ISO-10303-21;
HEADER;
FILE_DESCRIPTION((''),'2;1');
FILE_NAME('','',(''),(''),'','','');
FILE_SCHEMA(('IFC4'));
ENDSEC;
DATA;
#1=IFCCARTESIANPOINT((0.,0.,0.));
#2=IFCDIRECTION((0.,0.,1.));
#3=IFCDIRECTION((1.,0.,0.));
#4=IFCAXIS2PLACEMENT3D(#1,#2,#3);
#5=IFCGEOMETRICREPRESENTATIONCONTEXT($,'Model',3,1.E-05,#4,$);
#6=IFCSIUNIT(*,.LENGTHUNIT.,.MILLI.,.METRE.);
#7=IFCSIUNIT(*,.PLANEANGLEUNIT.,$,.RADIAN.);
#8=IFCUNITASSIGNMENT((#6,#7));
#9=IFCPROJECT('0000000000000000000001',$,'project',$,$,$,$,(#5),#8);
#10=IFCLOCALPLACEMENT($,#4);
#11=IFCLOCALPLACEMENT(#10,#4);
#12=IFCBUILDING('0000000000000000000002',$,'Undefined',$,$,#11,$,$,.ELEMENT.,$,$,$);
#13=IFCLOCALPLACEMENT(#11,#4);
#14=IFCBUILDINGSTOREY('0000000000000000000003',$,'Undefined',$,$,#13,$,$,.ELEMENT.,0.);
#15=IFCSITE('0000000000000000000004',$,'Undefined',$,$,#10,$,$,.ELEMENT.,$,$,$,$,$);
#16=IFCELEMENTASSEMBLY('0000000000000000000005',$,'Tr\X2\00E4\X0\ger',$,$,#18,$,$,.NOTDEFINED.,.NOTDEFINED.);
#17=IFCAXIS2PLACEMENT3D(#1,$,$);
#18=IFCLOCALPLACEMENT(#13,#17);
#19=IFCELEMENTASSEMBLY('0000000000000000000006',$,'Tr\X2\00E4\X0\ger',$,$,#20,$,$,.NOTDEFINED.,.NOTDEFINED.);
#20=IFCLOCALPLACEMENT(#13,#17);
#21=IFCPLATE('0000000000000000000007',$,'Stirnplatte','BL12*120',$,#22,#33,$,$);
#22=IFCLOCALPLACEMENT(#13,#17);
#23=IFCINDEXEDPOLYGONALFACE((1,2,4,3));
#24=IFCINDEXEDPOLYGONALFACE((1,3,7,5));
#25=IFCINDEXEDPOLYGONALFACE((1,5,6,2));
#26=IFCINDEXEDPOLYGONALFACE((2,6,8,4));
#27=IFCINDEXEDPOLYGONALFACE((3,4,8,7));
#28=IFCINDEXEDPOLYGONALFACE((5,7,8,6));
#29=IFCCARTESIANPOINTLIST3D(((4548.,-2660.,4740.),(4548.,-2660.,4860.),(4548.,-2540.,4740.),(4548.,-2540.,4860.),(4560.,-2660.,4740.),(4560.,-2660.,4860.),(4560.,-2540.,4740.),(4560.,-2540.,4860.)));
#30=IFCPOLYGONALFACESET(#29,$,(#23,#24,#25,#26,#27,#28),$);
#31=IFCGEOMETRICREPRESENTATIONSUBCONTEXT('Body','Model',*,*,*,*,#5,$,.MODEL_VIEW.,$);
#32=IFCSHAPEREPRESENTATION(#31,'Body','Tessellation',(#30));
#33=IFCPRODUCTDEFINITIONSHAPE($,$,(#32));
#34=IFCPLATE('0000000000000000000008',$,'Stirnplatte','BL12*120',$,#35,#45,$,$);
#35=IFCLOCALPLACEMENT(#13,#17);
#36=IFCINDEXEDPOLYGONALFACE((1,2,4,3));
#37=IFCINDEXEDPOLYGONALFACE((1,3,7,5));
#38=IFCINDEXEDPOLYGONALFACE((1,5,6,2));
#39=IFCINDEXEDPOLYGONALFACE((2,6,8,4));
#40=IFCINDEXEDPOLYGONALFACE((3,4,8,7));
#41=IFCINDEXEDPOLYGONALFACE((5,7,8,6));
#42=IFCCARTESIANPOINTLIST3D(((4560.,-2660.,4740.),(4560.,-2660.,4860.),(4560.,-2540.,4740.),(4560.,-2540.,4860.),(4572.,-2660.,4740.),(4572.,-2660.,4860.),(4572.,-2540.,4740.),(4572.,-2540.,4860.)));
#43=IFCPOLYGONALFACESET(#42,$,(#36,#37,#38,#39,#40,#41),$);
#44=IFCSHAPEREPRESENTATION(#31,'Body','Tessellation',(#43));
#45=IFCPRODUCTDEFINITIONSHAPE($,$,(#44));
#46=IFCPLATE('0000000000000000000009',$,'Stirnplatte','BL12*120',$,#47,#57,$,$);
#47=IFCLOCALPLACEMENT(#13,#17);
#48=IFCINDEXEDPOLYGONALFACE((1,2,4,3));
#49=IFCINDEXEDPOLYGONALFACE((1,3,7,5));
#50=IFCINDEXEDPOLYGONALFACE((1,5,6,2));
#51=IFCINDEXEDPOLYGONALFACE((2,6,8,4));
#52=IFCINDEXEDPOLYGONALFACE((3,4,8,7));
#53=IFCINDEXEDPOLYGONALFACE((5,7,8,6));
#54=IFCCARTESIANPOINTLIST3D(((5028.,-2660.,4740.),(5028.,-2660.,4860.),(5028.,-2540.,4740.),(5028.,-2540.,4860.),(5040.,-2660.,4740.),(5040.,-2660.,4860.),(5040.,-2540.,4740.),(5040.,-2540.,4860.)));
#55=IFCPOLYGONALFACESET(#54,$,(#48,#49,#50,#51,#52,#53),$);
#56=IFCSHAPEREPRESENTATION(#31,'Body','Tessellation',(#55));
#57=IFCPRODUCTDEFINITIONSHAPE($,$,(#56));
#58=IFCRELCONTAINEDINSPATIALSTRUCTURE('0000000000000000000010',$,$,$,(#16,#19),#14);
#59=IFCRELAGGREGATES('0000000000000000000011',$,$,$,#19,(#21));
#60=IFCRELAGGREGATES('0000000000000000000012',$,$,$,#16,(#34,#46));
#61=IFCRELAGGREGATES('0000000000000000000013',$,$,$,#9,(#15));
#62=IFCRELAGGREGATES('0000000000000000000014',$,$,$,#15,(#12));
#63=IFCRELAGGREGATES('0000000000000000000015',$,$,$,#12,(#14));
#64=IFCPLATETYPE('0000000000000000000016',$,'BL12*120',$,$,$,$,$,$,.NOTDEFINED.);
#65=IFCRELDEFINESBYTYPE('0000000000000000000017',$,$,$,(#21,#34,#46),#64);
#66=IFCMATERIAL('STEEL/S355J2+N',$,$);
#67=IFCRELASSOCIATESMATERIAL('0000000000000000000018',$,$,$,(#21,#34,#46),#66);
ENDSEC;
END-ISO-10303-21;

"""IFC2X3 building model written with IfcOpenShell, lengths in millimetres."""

from ifc_helpers import new_model, si_unit, frame, origin_with_axes, place, context, subcontext, project, spatial, polyline, outline, extrude, material, type_object, element, aggregate, save


model = new_model("IFC2X3")

# Units and contexts
model_context = context("Model", 3, precision=1e-05, world=origin_with_axes())
body_context = subcontext(model_context, "Body", "Model", "MODEL_VIEW")
ifc_project = project(units=[si_unit("LENGTHUNIT", "METRE", prefix="MILLI"), si_unit("PLANEANGLEUNIT", "RADIAN")], contexts=[model_context])

# Site, building, storey
site_placement = place(None, origin_with_axes())
site = spatial("IfcSite", under=ifc_project, at=site_placement, Name="Undefined", CompositionType="ELEMENT")
building_placement = place(site_placement, origin_with_axes())
building = spatial("IfcBuilding", under=site, at=building_placement, Name="Undefined", CompositionType="ELEMENT")
storey_placement = place(building_placement, origin_with_axes())
storey = spatial("IfcBuildingStorey", under=building, at=storey_placement, Name="Undefined", CompositionType="ELEMENT", Elevation=0.0)

# Element assembly
assembly_1_placement = place(storey_placement, origin_with_axes())
assembly_1 = element("IfcElementAssembly", 1, at=assembly_1_placement, inside=storey, Name="Träger", AssemblyPlace="NOTDEFINED", PredefinedType="NOTDEFINED")

# Shared definitions
ifc_material_1 = material(Name="STEEL/S355J2+N")
plate_type_1 = type_object("IfcPlateType", Name="BL12*120", PredefinedType="NOTDEFINED")

# Element assembly, plate
assembly_2_placement = place(storey_placement, origin_with_axes())
assembly_2 = element("IfcElementAssembly", 2, at=assembly_2_placement, inside=storey, Name="Träger", AssemblyPlace="NOTDEFINED", PredefinedType="NOTDEFINED")
plate_1_placement = place(assembly_2_placement, frame((4554.0, -2600.0, 4740.0), z_axis=(-1.0, 0.0, 0.0), x_axis=(0.0, 0.0, 1.0)))
plate_1 = element("IfcPlate", 3, at=plate_1_placement, type_object=plate_type_1, material=ifc_material_1, Name="Stirnplatte", Description="BL12*120", context=body_context, shape_type="SweptSolid", body=[
    extrude(outline(polyline([(0.0, -60.0), (0.0, 60.0), (120.0, 60.0), (120.0, -60.0), (0.0, -60.0)])), frame((0.0, 0.0, -6.0), z_axis=(0.0, 0.0, 1.0), x_axis=(1.0, 0.0, 0.0)), (0.0, 0.0, 1.0), 12.0),
])
aggregate(assembly_2, [plate_1])

# Plates
plate_2_placement = place(assembly_1_placement, frame((4566.0, -2600.0, 4740.0), z_axis=(-1.0, 0.0, 0.0), x_axis=(0.0, 0.0, 1.0)))
plate_2 = element("IfcPlate", 4, at=plate_2_placement, type_object=plate_type_1, material=ifc_material_1, Name="Stirnplatte", Description="BL12*120", context=body_context, shape_type="SweptSolid", body=[
    extrude(outline(polyline([(0.0, -60.0), (0.0, 60.0), (120.0, 60.0), (120.0, -60.0), (0.0, -60.0)])), frame((0.0, 0.0, -6.0), z_axis=(0.0, 0.0, 1.0), x_axis=(1.0, 0.0, 0.0)), (0.0, 0.0, 1.0), 12.0),
])
plate_3_placement = place(assembly_1_placement, frame((5034.0, -2600.0, 4740.0), z_axis=(1.0, 0.0, 0.0), x_axis=(0.0, 0.0, 1.0)))
plate_3 = element("IfcPlate", 5, at=plate_3_placement, type_object=plate_type_1, material=ifc_material_1, Name="Stirnplatte", Description="BL12*120", context=body_context, shape_type="SweptSolid", body=[
    extrude(outline(polyline([(0.0, -60.0), (0.0, 60.0), (120.0, 60.0), (120.0, -60.0), (0.0, -60.0)])), frame((0.0, 0.0, -6.0), z_axis=(0.0, 0.0, 1.0), x_axis=(1.0, 0.0, 0.0)), (0.0, 0.0, 1.0), 12.0),
])
aggregate(assembly_1, [plate_2, plate_3])

save(model, "model.ifc")
